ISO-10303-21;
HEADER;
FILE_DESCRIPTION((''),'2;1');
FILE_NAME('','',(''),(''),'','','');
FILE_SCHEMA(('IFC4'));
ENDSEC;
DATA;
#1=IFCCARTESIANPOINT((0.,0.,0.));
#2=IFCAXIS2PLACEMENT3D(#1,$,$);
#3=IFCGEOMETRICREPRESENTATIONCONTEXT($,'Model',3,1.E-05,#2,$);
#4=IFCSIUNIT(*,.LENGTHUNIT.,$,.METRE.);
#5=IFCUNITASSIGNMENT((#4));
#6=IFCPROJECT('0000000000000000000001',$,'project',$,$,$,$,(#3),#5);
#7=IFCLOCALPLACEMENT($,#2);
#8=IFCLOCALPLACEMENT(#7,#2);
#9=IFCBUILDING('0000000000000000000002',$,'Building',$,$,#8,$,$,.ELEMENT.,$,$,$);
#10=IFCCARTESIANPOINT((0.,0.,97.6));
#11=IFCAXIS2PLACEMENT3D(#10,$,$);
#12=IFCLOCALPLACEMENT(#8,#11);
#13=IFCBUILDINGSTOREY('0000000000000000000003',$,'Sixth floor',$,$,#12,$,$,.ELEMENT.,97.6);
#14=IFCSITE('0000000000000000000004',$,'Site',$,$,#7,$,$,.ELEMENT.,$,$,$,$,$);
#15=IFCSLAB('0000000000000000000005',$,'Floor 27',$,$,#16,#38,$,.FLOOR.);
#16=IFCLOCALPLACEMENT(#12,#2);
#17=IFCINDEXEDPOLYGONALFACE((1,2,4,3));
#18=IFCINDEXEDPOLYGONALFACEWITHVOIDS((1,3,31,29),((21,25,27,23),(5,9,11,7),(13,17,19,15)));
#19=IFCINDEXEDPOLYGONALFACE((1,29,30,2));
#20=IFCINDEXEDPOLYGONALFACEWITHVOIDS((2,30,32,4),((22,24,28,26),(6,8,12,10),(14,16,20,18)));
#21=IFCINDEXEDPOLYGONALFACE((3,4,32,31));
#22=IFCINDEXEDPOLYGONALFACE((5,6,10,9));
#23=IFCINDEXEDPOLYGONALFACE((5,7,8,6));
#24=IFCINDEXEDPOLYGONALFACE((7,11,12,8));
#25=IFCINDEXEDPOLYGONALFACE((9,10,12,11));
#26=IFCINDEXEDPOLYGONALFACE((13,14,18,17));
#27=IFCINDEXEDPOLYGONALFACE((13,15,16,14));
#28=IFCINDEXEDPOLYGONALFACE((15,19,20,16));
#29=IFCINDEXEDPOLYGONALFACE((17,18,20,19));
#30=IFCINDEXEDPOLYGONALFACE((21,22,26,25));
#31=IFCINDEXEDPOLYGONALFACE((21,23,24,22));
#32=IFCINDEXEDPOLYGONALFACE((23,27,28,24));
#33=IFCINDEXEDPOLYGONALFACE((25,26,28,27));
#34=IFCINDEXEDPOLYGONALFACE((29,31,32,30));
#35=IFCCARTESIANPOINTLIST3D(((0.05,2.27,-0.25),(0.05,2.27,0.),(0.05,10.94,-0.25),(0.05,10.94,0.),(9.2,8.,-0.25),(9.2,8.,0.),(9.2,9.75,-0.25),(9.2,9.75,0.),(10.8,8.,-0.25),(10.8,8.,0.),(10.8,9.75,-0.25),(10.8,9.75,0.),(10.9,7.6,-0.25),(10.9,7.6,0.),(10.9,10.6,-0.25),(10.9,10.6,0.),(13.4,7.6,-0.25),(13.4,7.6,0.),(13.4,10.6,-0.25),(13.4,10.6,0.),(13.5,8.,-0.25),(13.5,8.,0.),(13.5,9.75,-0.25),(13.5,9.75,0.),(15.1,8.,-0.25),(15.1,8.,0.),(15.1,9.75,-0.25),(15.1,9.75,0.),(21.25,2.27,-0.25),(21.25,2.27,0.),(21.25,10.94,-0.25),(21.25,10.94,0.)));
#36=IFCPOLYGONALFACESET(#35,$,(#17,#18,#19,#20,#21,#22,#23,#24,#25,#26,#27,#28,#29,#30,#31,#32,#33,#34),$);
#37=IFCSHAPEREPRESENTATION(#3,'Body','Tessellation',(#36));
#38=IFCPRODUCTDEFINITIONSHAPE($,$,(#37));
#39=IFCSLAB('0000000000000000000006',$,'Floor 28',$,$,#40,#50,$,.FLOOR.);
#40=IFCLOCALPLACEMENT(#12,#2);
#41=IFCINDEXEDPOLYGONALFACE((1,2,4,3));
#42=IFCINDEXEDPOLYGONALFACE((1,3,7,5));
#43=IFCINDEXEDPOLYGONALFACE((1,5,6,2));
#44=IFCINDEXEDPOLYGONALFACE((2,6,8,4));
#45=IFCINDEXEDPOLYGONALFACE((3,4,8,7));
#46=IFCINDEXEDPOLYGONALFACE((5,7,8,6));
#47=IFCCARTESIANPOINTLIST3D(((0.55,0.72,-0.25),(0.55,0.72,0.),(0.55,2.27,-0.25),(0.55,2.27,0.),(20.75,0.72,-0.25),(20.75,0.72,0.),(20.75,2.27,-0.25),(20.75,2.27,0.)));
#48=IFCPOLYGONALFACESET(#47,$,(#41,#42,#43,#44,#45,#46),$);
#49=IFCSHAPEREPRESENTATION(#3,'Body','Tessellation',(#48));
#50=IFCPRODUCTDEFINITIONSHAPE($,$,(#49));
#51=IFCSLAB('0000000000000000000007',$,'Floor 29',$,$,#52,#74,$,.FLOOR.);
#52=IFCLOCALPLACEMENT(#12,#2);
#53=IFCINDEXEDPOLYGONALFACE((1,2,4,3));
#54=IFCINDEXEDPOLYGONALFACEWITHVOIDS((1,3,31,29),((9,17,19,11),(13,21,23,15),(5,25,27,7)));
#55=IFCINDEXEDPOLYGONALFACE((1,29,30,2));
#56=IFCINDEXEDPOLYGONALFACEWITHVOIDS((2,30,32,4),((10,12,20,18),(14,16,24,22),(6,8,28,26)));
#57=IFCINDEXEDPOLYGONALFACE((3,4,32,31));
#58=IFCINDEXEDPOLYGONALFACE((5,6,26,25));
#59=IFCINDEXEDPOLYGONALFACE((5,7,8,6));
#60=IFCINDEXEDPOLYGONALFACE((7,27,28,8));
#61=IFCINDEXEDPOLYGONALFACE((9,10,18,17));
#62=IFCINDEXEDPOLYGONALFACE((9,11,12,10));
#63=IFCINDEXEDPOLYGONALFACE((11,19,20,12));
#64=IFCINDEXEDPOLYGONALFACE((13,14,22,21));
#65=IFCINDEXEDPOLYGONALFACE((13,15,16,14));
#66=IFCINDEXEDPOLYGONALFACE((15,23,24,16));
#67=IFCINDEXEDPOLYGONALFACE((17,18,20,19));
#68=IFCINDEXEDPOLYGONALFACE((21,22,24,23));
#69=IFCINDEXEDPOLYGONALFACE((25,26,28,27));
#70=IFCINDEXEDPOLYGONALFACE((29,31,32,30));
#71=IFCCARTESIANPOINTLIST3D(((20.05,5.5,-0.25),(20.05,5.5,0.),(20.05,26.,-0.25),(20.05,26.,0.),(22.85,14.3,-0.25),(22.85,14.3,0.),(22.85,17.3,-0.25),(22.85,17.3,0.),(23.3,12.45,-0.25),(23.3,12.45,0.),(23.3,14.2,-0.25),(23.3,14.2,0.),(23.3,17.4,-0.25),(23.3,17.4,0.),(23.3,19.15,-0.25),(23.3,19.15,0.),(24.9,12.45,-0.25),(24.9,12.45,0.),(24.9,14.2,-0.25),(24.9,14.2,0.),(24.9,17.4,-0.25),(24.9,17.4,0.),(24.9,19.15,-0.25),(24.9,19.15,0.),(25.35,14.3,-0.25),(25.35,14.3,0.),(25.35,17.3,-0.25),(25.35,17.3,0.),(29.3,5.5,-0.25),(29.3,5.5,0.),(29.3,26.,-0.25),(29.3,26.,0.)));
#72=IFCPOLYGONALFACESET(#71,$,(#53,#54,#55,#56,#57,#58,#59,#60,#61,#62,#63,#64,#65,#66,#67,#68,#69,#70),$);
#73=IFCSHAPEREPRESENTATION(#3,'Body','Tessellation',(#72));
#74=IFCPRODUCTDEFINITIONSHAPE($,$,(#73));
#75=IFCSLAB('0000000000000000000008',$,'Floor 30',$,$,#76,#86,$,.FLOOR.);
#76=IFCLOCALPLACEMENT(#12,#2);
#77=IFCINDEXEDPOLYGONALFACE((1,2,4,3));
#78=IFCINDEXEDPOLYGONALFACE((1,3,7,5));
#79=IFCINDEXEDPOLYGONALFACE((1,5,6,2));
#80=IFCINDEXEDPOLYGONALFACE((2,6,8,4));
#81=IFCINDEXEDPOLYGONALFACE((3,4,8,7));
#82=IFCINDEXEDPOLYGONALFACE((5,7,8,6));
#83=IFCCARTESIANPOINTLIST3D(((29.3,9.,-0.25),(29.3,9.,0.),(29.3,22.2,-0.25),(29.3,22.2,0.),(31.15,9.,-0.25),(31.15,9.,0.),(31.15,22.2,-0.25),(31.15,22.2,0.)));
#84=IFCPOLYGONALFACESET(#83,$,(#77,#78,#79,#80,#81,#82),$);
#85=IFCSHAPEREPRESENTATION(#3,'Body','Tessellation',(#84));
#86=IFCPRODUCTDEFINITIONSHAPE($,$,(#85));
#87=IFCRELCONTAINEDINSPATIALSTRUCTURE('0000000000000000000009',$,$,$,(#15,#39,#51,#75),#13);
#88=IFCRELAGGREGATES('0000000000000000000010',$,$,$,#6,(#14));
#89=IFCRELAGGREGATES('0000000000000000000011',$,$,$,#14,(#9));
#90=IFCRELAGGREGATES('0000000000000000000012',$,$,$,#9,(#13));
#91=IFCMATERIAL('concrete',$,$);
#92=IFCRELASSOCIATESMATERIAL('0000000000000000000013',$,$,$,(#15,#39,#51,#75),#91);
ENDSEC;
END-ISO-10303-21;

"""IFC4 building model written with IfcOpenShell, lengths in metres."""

from ifc_helpers import new_model, si_unit, frame, origin, place, context, project, spatial, polyline, outline, extrude, material, element, save


model = new_model("IFC4")

# Units and contexts
model_context = context("Model", 3, precision=1e-05, world=origin())
ifc_project = project(units=[si_unit("LENGTHUNIT", "METRE")], contexts=[model_context])

# Site, building, storey
site_placement = place(None, origin())
site = spatial("IfcSite", under=ifc_project, at=site_placement, Name="Site", CompositionType="ELEMENT")
building_placement = place(site_placement, origin())
building = spatial("IfcBuilding", under=site, at=building_placement, Name="Building", CompositionType="ELEMENT")
storey_placement = place(building_placement, frame((0.0, 0.0, 97.6)))
storey = spatial("IfcBuildingStorey", under=building, at=storey_placement, Name="Sixth floor", CompositionType="ELEMENT", Elevation=97.6)

# Slabs
ifc_material = material(Name="concrete")
slab_1_placement = place(storey_placement, frame((0.0, 0.0, -0.25), z_axis=(0.0, 0.0, 1.0), x_axis=(1.0, 0.0, 0.0)))
element("IfcSlab", 1, at=slab_1_placement, inside=storey, material=ifc_material, Name="Floor 27", PredefinedType="FLOOR", context=model_context, shape_type="SweptSolid", body=[
    extrude(outline(polyline([(0.05, 2.27), (21.25, 2.27), (21.25, 10.94), (0.05, 10.94), (0.05, 2.27)]), holes=[polyline([(10.9, 7.6), (13.4, 7.6), (13.4, 10.6), (10.9, 10.6), (10.9, 7.6)]), polyline([(9.2, 8.0), (10.8, 8.0), (10.8, 9.75), (9.2, 9.75), (9.2, 8.0)]), polyline([(13.5, 8.0), (15.1, 8.0), (15.1, 9.75), (13.5, 9.75), (13.5, 8.0)])]), origin(), (0.0, 0.0, 1.0), 0.25),
])
slab_2_placement = place(storey_placement, frame((0.0, 0.0, -0.25), z_axis=(0.0, 0.0, 1.0), x_axis=(1.0, 0.0, 0.0)))
element("IfcSlab", 2, at=slab_2_placement, inside=storey, material=ifc_material, Name="Floor 28", PredefinedType="FLOOR", context=model_context, shape_type="SweptSolid", body=[
    extrude(outline(polyline([(0.55, 0.72), (20.75, 0.72), (20.75, 2.27), (0.55, 2.27), (0.55, 0.72)])), origin(), (0.0, 0.0, 1.0), 0.25),
])
slab_3_placement = place(storey_placement, frame((0.0, 0.0, -0.25), z_axis=(0.0, 0.0, 1.0), x_axis=(1.0, 0.0, 0.0)))
element("IfcSlab", 3, at=slab_3_placement, inside=storey, material=ifc_material, Name="Floor 29", PredefinedType="FLOOR", context=model_context, shape_type="SweptSolid", body=[
    extrude(outline(polyline([(20.05, 5.5), (29.3, 5.5), (29.3, 26.0), (20.05, 26.0), (20.05, 5.5)]), holes=[polyline([(22.85, 14.3), (25.35, 14.3), (25.35, 17.3), (22.85, 17.3), (22.85, 14.3)]), polyline([(23.3, 17.4), (24.9, 17.4), (24.9, 19.15), (23.3, 19.15), (23.3, 17.4)]), polyline([(23.3, 12.45), (24.9, 12.45), (24.9, 14.2), (23.3, 14.2), (23.3, 12.45)])]), origin(), (0.0, 0.0, 1.0), 0.25),
])
slab_4_placement = place(storey_placement, frame((0.0, 0.0, -0.25), z_axis=(0.0, 0.0, 1.0), x_axis=(1.0, 0.0, 0.0)))
element("IfcSlab", 4, at=slab_4_placement, inside=storey, material=ifc_material, Name="Floor 30", PredefinedType="FLOOR", context=model_context, shape_type="SweptSolid", body=[
    extrude(outline(polyline([(29.3, 9.0), (31.15, 9.0), (31.15, 22.2), (29.3, 22.2), (29.3, 9.0)])), origin(), (0.0, 0.0, 1.0), 0.25),
])

save(model, "model.ifc")
